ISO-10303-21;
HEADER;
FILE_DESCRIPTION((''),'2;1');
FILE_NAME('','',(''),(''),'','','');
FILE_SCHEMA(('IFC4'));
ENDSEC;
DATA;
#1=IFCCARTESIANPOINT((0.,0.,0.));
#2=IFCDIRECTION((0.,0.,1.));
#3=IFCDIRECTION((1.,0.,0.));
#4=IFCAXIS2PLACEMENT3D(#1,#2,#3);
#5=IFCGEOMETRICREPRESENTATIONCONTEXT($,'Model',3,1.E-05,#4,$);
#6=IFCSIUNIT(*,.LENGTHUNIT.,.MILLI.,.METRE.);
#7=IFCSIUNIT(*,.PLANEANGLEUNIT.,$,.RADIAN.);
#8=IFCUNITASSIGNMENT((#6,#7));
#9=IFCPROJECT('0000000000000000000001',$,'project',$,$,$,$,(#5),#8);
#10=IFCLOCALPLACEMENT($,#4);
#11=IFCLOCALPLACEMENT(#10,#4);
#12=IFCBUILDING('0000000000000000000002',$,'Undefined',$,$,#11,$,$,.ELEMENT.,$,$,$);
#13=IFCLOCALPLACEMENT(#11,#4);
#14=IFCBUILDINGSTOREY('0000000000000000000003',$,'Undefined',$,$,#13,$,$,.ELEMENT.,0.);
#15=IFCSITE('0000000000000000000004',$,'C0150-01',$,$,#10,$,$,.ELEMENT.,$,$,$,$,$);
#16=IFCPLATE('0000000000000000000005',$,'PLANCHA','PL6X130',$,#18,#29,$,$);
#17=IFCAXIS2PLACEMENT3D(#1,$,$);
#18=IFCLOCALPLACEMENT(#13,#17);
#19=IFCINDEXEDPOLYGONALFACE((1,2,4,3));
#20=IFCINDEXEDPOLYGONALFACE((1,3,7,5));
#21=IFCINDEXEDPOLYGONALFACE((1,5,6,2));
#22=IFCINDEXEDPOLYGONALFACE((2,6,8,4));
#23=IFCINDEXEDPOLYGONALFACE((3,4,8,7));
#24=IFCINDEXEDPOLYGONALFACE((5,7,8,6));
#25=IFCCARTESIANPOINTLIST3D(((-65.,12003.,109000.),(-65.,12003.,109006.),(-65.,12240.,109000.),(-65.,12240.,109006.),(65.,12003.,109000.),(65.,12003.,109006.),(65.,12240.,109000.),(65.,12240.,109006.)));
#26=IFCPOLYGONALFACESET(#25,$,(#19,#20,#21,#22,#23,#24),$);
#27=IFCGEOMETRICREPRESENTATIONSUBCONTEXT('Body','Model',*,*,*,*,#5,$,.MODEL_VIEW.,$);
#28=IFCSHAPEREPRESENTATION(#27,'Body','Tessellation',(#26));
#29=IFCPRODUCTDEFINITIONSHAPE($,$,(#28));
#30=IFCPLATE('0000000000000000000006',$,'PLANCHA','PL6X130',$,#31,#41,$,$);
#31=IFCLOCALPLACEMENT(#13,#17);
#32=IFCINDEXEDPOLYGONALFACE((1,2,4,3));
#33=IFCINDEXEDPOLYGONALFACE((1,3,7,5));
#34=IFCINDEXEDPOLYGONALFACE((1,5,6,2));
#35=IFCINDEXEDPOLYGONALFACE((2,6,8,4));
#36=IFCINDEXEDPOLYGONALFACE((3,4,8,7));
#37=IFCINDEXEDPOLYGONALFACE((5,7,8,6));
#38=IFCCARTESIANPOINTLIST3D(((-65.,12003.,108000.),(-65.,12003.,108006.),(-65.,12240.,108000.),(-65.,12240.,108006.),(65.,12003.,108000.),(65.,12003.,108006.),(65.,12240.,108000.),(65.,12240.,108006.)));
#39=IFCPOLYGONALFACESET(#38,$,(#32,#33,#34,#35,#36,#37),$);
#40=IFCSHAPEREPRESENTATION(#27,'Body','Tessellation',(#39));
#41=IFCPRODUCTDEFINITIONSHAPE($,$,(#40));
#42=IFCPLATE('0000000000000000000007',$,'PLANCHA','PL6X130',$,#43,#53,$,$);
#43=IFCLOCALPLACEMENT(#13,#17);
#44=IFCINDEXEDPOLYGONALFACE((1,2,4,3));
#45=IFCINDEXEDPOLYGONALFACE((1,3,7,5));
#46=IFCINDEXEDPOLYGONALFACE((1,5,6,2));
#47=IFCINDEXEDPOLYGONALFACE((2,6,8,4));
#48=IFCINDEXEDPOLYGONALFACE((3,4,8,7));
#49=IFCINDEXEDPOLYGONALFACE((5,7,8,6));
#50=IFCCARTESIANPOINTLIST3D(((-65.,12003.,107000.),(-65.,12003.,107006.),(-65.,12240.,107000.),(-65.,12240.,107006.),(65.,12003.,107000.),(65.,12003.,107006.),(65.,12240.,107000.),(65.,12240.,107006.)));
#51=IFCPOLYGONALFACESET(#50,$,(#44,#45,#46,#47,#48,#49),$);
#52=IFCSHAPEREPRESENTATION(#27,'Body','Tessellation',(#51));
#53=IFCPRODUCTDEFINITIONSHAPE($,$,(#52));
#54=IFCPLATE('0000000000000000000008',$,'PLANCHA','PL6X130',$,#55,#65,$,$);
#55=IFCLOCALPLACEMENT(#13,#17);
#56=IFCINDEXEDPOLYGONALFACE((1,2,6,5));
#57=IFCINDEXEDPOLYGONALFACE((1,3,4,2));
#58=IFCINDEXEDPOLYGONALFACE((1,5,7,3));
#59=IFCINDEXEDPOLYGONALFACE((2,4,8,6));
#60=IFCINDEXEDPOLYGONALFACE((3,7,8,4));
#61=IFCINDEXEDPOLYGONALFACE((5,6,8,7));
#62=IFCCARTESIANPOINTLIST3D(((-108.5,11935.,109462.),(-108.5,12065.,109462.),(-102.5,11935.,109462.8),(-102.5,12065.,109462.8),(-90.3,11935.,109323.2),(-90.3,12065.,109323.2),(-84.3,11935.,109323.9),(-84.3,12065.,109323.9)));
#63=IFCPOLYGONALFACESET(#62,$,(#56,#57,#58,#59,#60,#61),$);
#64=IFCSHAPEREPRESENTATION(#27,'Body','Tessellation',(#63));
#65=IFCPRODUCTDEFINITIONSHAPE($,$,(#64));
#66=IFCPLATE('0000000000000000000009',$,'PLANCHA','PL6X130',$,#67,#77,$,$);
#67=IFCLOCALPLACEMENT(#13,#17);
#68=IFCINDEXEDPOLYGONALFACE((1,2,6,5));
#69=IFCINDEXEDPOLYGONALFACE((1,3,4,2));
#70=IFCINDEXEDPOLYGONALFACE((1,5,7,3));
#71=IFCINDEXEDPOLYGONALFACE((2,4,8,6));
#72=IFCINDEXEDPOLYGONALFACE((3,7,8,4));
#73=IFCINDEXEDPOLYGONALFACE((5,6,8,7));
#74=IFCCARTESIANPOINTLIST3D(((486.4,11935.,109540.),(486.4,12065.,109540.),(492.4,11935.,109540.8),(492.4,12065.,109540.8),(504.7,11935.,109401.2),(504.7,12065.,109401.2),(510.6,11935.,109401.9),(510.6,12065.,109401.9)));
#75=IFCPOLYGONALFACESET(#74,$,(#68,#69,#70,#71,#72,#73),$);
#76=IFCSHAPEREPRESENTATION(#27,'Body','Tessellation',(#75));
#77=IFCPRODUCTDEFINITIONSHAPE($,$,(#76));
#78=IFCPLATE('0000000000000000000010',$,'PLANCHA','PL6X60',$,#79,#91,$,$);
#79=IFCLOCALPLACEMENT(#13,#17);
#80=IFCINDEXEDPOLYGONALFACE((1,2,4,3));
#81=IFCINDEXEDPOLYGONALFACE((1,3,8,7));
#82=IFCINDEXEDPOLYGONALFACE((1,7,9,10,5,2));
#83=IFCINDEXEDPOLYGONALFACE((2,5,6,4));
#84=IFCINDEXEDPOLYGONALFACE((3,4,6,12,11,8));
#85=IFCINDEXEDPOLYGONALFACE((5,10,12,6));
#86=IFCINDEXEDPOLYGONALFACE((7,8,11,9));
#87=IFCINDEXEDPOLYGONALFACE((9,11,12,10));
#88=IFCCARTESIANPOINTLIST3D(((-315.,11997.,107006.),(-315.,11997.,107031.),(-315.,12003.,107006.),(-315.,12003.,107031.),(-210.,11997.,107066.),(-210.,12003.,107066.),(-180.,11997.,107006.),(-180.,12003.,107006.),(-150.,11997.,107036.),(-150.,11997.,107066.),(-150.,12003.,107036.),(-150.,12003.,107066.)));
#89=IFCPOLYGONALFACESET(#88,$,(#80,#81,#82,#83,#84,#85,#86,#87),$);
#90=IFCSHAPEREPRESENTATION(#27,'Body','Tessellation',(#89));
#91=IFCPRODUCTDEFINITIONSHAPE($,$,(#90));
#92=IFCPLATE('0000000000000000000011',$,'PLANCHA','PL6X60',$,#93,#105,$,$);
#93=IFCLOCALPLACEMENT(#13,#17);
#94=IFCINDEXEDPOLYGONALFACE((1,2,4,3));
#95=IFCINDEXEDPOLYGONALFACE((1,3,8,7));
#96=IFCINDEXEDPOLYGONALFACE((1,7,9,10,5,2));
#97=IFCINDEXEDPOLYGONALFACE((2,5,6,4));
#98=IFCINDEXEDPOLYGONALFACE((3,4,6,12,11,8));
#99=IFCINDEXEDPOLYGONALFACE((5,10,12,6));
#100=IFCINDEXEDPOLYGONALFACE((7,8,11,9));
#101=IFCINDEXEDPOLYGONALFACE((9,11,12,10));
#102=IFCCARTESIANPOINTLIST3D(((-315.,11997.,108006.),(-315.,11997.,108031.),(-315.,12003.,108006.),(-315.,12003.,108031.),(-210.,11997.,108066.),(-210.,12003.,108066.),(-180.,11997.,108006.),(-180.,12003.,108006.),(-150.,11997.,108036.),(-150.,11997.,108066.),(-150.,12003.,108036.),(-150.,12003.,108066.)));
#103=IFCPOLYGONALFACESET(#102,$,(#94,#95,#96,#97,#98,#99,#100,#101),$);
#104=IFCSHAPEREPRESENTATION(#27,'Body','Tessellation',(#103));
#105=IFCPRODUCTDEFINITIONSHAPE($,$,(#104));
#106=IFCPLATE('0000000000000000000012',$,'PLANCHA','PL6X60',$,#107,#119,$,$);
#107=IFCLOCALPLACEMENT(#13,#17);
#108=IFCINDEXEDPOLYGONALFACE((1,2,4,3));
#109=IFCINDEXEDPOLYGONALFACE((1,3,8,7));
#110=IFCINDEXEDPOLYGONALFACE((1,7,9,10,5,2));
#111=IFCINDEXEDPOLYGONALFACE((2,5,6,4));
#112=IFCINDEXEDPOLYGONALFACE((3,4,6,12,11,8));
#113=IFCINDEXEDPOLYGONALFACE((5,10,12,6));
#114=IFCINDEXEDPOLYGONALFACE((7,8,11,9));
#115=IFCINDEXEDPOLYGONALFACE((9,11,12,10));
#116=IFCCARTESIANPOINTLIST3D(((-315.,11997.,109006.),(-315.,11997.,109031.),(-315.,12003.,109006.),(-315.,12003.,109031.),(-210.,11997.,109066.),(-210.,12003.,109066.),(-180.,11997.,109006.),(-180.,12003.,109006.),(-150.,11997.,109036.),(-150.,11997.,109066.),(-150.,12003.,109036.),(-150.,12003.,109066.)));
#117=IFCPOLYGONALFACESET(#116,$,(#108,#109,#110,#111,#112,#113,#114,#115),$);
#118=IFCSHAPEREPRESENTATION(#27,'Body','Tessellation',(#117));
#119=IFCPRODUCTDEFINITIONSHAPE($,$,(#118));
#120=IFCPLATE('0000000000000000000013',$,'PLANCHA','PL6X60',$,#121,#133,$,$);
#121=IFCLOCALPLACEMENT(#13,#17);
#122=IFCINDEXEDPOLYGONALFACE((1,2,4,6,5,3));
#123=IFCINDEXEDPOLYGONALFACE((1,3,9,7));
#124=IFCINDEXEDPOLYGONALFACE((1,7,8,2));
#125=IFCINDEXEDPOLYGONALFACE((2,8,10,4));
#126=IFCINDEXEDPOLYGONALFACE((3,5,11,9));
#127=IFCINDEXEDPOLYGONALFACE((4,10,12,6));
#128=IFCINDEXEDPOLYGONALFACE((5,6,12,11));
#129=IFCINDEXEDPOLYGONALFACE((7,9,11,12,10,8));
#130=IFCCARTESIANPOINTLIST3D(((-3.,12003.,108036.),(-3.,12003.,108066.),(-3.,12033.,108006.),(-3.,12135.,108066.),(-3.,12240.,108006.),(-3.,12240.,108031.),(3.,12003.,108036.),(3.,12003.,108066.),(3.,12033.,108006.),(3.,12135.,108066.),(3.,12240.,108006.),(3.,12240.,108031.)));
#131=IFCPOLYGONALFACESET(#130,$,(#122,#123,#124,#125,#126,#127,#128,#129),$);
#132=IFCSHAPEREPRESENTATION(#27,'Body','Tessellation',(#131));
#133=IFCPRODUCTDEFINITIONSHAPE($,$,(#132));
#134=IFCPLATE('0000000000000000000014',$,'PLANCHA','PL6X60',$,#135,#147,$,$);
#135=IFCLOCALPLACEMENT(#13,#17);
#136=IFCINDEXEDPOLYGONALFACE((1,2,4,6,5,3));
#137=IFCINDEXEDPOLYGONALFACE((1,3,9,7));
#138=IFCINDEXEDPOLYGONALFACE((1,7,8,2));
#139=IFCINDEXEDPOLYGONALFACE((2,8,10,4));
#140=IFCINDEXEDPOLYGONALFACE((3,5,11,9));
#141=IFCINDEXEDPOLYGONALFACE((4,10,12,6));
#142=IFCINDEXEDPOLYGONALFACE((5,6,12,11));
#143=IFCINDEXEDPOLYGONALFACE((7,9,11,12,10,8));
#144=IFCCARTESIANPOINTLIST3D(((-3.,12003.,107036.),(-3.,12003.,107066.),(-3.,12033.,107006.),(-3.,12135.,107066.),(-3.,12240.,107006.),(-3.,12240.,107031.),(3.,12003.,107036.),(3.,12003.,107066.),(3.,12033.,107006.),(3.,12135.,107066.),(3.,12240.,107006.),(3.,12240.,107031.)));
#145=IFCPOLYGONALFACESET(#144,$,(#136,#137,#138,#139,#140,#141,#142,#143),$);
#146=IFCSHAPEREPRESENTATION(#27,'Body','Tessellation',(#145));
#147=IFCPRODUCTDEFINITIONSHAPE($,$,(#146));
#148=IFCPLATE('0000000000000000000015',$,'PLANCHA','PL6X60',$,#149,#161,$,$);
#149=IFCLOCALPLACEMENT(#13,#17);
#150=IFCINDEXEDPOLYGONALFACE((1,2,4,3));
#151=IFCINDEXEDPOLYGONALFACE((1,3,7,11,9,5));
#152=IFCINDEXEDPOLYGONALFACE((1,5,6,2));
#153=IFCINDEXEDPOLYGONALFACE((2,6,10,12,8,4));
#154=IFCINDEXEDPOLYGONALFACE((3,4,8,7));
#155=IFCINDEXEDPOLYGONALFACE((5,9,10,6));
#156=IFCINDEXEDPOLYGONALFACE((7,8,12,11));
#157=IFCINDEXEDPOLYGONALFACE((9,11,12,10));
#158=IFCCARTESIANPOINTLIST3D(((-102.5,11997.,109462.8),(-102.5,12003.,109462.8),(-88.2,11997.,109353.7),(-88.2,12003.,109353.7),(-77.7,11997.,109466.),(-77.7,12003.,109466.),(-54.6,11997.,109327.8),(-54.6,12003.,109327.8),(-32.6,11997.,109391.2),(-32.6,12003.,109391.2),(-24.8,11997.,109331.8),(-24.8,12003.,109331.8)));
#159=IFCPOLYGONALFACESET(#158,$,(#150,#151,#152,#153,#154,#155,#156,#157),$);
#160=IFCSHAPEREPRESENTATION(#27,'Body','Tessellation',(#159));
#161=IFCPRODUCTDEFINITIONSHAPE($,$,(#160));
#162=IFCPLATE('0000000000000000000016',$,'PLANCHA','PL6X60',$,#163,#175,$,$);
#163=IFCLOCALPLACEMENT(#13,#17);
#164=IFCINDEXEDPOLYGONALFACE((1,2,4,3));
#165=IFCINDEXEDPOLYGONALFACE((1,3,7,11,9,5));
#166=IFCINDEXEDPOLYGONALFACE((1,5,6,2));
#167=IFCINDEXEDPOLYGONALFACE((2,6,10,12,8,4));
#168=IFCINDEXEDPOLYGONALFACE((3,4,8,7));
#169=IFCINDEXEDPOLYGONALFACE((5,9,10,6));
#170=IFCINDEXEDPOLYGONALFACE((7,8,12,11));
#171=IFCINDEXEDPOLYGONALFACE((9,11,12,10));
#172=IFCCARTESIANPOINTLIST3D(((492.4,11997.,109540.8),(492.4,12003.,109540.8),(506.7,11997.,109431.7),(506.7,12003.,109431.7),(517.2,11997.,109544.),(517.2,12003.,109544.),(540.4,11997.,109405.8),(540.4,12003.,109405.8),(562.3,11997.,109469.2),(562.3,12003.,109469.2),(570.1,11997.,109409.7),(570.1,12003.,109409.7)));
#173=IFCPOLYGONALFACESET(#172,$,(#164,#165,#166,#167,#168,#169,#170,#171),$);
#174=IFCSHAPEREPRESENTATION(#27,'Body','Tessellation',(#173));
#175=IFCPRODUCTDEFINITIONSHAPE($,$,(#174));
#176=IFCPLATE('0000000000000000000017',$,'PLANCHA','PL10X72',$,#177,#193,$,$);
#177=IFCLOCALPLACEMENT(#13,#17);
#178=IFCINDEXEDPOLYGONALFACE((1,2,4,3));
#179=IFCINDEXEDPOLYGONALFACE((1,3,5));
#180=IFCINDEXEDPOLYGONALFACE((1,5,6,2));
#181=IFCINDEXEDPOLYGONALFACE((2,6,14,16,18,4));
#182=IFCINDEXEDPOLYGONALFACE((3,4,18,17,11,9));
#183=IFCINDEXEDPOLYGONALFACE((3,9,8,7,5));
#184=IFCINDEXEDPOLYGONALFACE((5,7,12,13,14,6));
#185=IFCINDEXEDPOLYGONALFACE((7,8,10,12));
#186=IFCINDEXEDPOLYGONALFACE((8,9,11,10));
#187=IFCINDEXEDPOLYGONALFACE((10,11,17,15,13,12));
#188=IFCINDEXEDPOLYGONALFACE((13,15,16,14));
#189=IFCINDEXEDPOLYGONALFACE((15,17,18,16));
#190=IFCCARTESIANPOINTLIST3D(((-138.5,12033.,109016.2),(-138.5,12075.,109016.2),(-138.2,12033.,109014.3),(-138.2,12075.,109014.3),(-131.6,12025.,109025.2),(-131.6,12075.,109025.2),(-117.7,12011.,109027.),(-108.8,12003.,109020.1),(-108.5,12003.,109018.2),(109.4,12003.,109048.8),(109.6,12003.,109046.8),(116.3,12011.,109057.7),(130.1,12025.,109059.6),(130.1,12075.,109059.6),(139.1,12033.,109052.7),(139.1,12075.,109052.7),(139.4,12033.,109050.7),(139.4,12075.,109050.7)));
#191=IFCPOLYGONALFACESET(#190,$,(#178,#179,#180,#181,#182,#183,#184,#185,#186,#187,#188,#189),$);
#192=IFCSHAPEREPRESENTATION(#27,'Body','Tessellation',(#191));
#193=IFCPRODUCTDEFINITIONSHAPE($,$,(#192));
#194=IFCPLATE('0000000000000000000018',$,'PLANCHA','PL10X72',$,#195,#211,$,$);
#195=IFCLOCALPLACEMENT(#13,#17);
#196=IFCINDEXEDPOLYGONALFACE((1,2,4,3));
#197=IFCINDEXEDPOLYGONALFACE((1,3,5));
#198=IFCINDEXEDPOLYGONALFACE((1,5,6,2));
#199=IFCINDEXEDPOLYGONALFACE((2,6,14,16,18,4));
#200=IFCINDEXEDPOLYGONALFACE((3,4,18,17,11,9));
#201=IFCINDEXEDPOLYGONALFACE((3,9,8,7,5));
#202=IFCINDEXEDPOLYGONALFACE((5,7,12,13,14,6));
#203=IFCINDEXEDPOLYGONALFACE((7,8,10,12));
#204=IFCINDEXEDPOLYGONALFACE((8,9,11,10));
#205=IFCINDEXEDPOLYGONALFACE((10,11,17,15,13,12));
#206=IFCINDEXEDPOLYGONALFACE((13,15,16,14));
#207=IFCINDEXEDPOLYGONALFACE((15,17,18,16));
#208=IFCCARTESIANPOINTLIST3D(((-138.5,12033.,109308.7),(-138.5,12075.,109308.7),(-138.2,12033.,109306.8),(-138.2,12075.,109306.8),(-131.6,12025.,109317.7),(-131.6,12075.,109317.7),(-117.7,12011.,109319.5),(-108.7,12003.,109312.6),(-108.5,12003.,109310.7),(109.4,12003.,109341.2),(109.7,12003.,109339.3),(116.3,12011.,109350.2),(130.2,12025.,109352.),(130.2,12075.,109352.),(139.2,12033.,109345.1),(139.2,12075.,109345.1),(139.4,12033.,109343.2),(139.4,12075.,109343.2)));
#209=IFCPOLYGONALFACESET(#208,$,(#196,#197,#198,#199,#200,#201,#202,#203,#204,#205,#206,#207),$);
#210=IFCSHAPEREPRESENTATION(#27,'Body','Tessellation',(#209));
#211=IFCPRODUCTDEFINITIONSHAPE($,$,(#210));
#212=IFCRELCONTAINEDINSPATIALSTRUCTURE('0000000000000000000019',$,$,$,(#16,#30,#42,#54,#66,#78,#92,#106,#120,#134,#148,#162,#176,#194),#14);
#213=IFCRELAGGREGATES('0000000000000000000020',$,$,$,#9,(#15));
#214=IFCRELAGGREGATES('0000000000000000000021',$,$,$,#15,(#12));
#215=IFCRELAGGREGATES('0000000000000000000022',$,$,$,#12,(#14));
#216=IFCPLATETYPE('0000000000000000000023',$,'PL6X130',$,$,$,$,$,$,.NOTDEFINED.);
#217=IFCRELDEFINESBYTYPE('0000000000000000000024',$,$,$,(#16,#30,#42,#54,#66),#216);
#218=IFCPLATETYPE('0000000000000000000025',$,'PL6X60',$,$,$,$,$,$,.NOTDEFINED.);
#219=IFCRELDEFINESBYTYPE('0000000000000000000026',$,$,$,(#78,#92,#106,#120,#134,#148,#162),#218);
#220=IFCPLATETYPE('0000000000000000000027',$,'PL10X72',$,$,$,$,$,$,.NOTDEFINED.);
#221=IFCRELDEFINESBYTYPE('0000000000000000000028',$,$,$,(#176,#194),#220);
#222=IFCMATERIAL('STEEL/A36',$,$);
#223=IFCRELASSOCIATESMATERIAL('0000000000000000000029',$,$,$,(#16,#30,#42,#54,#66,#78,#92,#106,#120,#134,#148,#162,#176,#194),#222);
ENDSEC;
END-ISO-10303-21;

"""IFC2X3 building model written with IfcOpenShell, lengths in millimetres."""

from ifc_helpers import new_model, si_unit, frame, origin_with_axes, place, context, subcontext, project, spatial, polyline, outline, extrude, boolean, material, type_object, element, save


model = new_model("IFC2X3")

# Units and contexts
model_context = context("Model", 3, precision=1e-05, world=origin_with_axes())
body_context = subcontext(model_context, "Body", "Model", "MODEL_VIEW")
ifc_project = project(units=[si_unit("LENGTHUNIT", "METRE", prefix="MILLI"), si_unit("PLANEANGLEUNIT", "RADIAN")], contexts=[model_context])

# Site, building, storey
site_placement = place(None, origin_with_axes())
site = spatial("IfcSite", under=ifc_project, at=site_placement, Name="C0150-01", CompositionType="ELEMENT")
building_placement = place(site_placement, origin_with_axes())
building = spatial("IfcBuilding", under=site, at=building_placement, Name="Undefined", CompositionType="ELEMENT")
storey_placement = place(building_placement, origin_with_axes())
storey = spatial("IfcBuildingStorey", under=building, at=storey_placement, Name="Undefined", CompositionType="ELEMENT", Elevation=0.0)

# Shared definitions
ifc_material_1 = material(Name="STEEL/A36")

# Plates
plate_type_1 = type_object("IfcPlateType", Name="PL6X130", PredefinedType="NOTDEFINED")
for number, where, z_axis, x_axis, name in (
    (1, (65.0, 12003.0, 109003.0), (0.0, 0.000002, -1.0), (-1.0, 0.0, 0.0), "PLANCHA"),
    (2, (65.0, 12003.0, 108003.0), (0.0, 0.000002, -1.0), (-1.0, 0.0, 0.0), "PLANCHA"),
    (3, (65.0, 12003.0, 107003.0), (0.0, 0.000002, -1.0), (-1.0, 0.0, 0.0), "PLANCHA"),
):
    element("IfcPlate", number, at=place(storey_placement, frame(where, z_axis=z_axis, x_axis=x_axis)), inside=storey, type_object=plate_type_1, material=ifc_material_1, Name=name, Description="PL6X130", context=body_context, shape_type="SweptSolid", body=[
        extrude(outline(polyline([(0.0, 0.0), (130.0, 0.0), (130.0, 237.0), (0.0, 237.0), (0.0, 0.0)])), frame((0.0, 0.0, -3.0), z_axis=(0.0, 0.0, 1.0), x_axis=(1.0, 0.0, 0.0)), (0.0, 0.0, 1.0), 6.0),
    ])
for number, where, z_axis, x_axis, name in (
    (4, (-87.3, 12065.0, 109323.6), (-0.991507, 0.0, -0.130054), (0.0, -1.0, 0.0), "PLANCHA"),
    (5, (507.6, 12065.0, 109401.5), (-0.991507, 0.0, -0.130054), (0.0, -1.0, 0.0), "PLANCHA"),
):
    element("IfcPlate", number, at=place(storey_placement, frame(where, z_axis=z_axis, x_axis=x_axis)), inside=storey, type_object=plate_type_1, material=ifc_material_1, Name=name, Description="PL6X130", context=body_context, shape_type="SweptSolid", body=[
        extrude(outline(polyline([(0.0, 0.0), (130.0, 0.0), (130.0, 140.0), (0.0, 140.0), (0.0, 0.0)])), frame((0.0, 0.0, -3.0), z_axis=(0.0, 0.0, 1.0), x_axis=(1.0, 0.0, 0.0)), (0.0, 0.0, 1.0), 6.0),
    ])
plate_type_2 = type_object("IfcPlateType", Name="PL6X60", PredefinedType="NOTDEFINED")
for number, where, z_axis, x_axis, name in (
    (6, (-315.0, 12000.0, 107031.0), (0.0, -1.0, 0.0), (-0.000004, 0.0, -1.0), "PLANCHA"),
    (7, (-315.0, 12000.0, 108031.0), (0.0, -1.0, 0.0), (-0.000004, 0.0, -1.0), "PLANCHA"),
    (8, (-315.0, 12000.0, 109031.0), (0.0, -1.0, 0.0), (-0.000004, 0.0, -1.0), "PLANCHA"),
):
    element("IfcPlate", number, at=place(storey_placement, frame(where, z_axis=z_axis, x_axis=x_axis)), inside=storey, type_object=plate_type_2, material=ifc_material_1, Name=name, Description="PL6X60", context=body_context, shape_type="SweptSolid", body=[
        extrude(outline(polyline([(0.0, 0.0), (25.0, 0.0), (25.0, 135.0), (-5.0, 165.0), (-35.0, 165.0), (-35.0, 105.0), (0.0, 0.0)])), frame((0.0, 0.0, -3.0), z_axis=(0.0, 0.0, 1.0), x_axis=(1.0, 0.0, 0.0)), (0.0, 0.0, 1.0), 6.0),
    ])
for number, where, z_axis, x_axis, name in (
    (9, (0.0, 12240.0, 108031.0), (-1.0, 0.0, 0.0), (0.0, 0.000004, -1.0), "PLANCHA"),
    (10, (0.0, 12240.0, 107031.0), (-1.0, 0.0, 0.0), (0.0, 0.000004, -1.0), "PLANCHA"),
):
    element("IfcPlate", number, at=place(storey_placement, frame(where, z_axis=z_axis, x_axis=x_axis)), inside=storey, type_object=plate_type_2, material=ifc_material_1, Name=name, Description="PL6X60", context=body_context, shape_type="SweptSolid", body=[
        extrude(outline(polyline([(0.0, 0.0), (25.0, 0.0), (25.0, 207.0), (-5.0, 237.0), (-35.0, 237.0), (-35.0, 105.0), (0.0, 0.0)])), frame((0.0, 0.0, -3.0), z_axis=(0.0, 0.0, 1.0), x_axis=(1.0, 0.0, 0.0)), (0.0, 0.0, 1.0), 6.0),
    ])
for number, where, z_axis, x_axis, name in (
    (11, (-77.7, 12000.0, 109466.0), (0.0, -1.0, 0.0), (-0.991507, 0.0, -0.130054), "PLANCHA"),
    (12, (517.2, 12000.0, 109544.0), (0.0, -1.0, 0.0), (-0.991507, 0.0, -0.130054), "PLANCHA"),
):
    element("IfcPlate", number, at=place(storey_placement, frame(where, z_axis=z_axis, x_axis=x_axis)), inside=storey, type_object=plate_type_2, material=ifc_material_1, Name=name, Description="PL6X60", context=body_context, shape_type="SweptSolid", body=[
        extrude(outline(polyline([(0.0, 0.0), (25.0, 0.0), (25.0, 110.0), (-5.0, 140.0), (-35.0, 140.0), (-35.0, 80.0), (0.0, 0.0)])), frame((0.0, 0.0, -3.0), z_axis=(0.0, 0.0, 1.0), x_axis=(1.0, 0.0, 0.0)), (0.0, 0.0, 1.0), 6.0),
    ])
plate_type_3 = type_object("IfcPlateType", Name="PL10X72", PredefinedType="NOTDEFINED")
for number, where, z_axis, x_axis, name in (
    (13, (-138.9, 12075.0, 109019.2), (0.130054, 0.0, -0.991507), (0.991507, 0.0, 0.130054), "PLANCHA"),
    (14, (-138.9, 12075.0, 109311.7), (0.130054, 0.0, -0.991507), (0.991507, 0.0, 0.130054), "PLANCHA"),
):
    element("IfcPlate", number, at=place(storey_placement, frame(where, z_axis=z_axis, x_axis=x_axis)), inside=storey, type_object=plate_type_3, material=ifc_material_1, Name=name, Description="PL10X72", context=body_context, shape_type="CSG", body=[
        boolean("DIFFERENCE", boolean("DIFFERENCE", boolean("DIFFERENCE", extrude(outline(polyline([(0.0, 0.0), (280.0, 0.0), (280.0, 42.0), (250.0, 72.0), (30.0, 72.0), (0.0, 42.0), (0.0, 0.0)])), frame((0.0, 0.0, -5.0), z_axis=(0.0, 0.0, 1.0), x_axis=(1.0, 0.0, 0.0)), (0.0, 0.0, 1.0), 10.0), extrude(outline(polyline([(0.0, 0.0), (8.0, 0.0), (8.0, 8.0), (0.0, 0.0)])), frame((282.5, 72.0, 3.0), z_axis=(-1.0, 0.0, 0.0), x_axis=(0.0, 0.0, -1.0)), (0.0, 0.0, 1.0), 285.0)), extrude(outline(polyline([(0.0, 0.0), (8.0, 0.0), (8.0, 8.0), (0.0, 0.0)])), frame((0.0, 74.5, 3.0), z_axis=(0.0, -1.0, 0.0), x_axis=(0.0, 0.0, -1.0)), (0.0, 0.0, 1.0), 77.0)), extrude(outline(polyline([(0.0, 0.0), (8.0, 0.0), (8.0, 8.0), (0.0, 0.0)])), frame((280.0, -2.5, 3.0), z_axis=(0.0, 1.0, 0.0), x_axis=(0.0, 0.0, -1.0)), (0.0, 0.0, 1.0), 77.0)),
    ])

save(model, "model.ifc")
